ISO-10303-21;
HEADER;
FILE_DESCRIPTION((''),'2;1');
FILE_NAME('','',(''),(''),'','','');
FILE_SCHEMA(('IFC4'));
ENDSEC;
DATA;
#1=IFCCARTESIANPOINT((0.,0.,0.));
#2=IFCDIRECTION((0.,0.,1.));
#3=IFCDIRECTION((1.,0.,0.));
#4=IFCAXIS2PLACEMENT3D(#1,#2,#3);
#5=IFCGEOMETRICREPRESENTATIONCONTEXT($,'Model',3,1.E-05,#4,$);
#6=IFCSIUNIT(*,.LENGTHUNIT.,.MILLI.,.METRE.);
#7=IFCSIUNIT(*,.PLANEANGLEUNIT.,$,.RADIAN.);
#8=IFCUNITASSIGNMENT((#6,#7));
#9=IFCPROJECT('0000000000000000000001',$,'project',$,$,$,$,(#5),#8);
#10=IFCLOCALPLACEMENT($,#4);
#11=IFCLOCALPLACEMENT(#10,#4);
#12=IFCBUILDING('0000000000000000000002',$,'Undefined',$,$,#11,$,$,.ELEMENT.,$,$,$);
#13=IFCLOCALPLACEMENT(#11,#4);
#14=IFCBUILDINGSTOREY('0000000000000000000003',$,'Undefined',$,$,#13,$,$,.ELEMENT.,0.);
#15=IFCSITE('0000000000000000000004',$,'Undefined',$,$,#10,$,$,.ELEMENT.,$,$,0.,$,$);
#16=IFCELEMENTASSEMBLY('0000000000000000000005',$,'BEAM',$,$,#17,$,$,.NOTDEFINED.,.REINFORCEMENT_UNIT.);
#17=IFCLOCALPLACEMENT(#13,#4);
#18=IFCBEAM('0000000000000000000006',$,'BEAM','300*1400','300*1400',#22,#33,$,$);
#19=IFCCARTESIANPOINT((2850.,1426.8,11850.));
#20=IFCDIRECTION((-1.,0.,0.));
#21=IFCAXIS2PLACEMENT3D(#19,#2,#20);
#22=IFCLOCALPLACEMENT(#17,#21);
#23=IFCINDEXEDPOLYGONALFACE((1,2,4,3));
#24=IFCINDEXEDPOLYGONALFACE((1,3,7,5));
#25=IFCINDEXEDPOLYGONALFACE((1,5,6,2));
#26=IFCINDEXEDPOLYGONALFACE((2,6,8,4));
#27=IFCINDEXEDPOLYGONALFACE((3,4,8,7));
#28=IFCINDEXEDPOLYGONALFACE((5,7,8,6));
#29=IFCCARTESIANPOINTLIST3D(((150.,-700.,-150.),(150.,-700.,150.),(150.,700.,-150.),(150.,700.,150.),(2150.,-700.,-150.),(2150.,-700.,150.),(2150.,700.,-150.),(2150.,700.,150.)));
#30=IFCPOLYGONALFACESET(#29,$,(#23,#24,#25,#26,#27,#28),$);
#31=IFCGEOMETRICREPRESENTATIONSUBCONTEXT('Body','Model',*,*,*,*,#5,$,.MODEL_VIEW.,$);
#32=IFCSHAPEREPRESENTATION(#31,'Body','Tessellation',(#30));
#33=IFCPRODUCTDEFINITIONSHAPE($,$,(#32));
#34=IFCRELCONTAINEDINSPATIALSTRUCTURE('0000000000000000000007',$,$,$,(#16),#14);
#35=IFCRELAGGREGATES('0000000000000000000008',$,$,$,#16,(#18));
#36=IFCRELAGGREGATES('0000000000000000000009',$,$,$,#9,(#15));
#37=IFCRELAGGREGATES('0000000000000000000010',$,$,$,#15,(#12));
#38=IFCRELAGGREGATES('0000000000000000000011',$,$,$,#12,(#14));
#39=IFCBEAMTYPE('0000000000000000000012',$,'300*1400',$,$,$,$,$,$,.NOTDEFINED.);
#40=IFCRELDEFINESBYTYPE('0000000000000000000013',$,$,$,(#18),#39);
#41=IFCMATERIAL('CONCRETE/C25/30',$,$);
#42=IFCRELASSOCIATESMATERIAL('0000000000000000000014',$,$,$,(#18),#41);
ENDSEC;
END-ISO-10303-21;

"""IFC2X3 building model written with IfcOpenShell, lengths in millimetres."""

from ifc_helpers import new_model, si_unit, frame, origin_with_axes, origin_2d_with_axis, place, context, subcontext, project, spatial, rectangle, extrude, material, type_object, element, aggregate, save


model = new_model("IFC2X3")

# Units and contexts
model_context = context("Model", 3, precision=1e-05, world=origin_with_axes())
body_context = subcontext(model_context, "Body", "Model", "MODEL_VIEW")
ifc_project = project(units=[si_unit("LENGTHUNIT", "METRE", prefix="MILLI"), si_unit("PLANEANGLEUNIT", "RADIAN")], contexts=[model_context])

# Site, building, storey
site_placement = place(None, origin_with_axes())
site = spatial("IfcSite", under=ifc_project, at=site_placement, Name="Undefined", CompositionType="ELEMENT", RefElevation=0.0)
building_placement = place(site_placement, origin_with_axes())
building = spatial("IfcBuilding", under=site, at=building_placement, Name="Undefined", CompositionType="ELEMENT")
storey_placement = place(building_placement, origin_with_axes())
storey = spatial("IfcBuildingStorey", under=building, at=storey_placement, Name="Undefined", CompositionType="ELEMENT", Elevation=0.0)

# Shared definitions
ifc_material_1 = material(Name="CONCRETE/C25/30")

# Element assembly, beam
beam_type_1 = type_object("IfcBeamType", Name="300*1400", PredefinedType="NOTDEFINED")
assembly_1_placement = place(storey_placement, origin_with_axes())
assembly_1 = element("IfcElementAssembly", 1, at=assembly_1_placement, inside=storey, Name="BEAM", AssemblyPlace="NOTDEFINED", PredefinedType="REINFORCEMENT_UNIT")
beam_1_placement = place(assembly_1_placement, frame((2850.0, 1426.8, 11850.0), z_axis=(0.0, 0.0, 1.0), x_axis=(-1.0, 0.0, 0.0)))
beam_1 = element("IfcBeam", 2, at=beam_1_placement, type_object=beam_type_1, material=ifc_material_1, Name="BEAM", Description="300*1400", ObjectType="300*1400", context=body_context, shape_type="SweptSolid", body=[
    extrude(rectangle(XDim=1400.0, YDim=300.0, at=origin_2d_with_axis()), frame((2150.0, 0.0, 0.0), z_axis=(-1.0, 0.0, 0.0), x_axis=(0.0, -1.0, 0.0)), (0.0, 0.0, 1.0), 2000.0),
])
aggregate(assembly_1, [beam_1])

save(model, "model.ifc")
